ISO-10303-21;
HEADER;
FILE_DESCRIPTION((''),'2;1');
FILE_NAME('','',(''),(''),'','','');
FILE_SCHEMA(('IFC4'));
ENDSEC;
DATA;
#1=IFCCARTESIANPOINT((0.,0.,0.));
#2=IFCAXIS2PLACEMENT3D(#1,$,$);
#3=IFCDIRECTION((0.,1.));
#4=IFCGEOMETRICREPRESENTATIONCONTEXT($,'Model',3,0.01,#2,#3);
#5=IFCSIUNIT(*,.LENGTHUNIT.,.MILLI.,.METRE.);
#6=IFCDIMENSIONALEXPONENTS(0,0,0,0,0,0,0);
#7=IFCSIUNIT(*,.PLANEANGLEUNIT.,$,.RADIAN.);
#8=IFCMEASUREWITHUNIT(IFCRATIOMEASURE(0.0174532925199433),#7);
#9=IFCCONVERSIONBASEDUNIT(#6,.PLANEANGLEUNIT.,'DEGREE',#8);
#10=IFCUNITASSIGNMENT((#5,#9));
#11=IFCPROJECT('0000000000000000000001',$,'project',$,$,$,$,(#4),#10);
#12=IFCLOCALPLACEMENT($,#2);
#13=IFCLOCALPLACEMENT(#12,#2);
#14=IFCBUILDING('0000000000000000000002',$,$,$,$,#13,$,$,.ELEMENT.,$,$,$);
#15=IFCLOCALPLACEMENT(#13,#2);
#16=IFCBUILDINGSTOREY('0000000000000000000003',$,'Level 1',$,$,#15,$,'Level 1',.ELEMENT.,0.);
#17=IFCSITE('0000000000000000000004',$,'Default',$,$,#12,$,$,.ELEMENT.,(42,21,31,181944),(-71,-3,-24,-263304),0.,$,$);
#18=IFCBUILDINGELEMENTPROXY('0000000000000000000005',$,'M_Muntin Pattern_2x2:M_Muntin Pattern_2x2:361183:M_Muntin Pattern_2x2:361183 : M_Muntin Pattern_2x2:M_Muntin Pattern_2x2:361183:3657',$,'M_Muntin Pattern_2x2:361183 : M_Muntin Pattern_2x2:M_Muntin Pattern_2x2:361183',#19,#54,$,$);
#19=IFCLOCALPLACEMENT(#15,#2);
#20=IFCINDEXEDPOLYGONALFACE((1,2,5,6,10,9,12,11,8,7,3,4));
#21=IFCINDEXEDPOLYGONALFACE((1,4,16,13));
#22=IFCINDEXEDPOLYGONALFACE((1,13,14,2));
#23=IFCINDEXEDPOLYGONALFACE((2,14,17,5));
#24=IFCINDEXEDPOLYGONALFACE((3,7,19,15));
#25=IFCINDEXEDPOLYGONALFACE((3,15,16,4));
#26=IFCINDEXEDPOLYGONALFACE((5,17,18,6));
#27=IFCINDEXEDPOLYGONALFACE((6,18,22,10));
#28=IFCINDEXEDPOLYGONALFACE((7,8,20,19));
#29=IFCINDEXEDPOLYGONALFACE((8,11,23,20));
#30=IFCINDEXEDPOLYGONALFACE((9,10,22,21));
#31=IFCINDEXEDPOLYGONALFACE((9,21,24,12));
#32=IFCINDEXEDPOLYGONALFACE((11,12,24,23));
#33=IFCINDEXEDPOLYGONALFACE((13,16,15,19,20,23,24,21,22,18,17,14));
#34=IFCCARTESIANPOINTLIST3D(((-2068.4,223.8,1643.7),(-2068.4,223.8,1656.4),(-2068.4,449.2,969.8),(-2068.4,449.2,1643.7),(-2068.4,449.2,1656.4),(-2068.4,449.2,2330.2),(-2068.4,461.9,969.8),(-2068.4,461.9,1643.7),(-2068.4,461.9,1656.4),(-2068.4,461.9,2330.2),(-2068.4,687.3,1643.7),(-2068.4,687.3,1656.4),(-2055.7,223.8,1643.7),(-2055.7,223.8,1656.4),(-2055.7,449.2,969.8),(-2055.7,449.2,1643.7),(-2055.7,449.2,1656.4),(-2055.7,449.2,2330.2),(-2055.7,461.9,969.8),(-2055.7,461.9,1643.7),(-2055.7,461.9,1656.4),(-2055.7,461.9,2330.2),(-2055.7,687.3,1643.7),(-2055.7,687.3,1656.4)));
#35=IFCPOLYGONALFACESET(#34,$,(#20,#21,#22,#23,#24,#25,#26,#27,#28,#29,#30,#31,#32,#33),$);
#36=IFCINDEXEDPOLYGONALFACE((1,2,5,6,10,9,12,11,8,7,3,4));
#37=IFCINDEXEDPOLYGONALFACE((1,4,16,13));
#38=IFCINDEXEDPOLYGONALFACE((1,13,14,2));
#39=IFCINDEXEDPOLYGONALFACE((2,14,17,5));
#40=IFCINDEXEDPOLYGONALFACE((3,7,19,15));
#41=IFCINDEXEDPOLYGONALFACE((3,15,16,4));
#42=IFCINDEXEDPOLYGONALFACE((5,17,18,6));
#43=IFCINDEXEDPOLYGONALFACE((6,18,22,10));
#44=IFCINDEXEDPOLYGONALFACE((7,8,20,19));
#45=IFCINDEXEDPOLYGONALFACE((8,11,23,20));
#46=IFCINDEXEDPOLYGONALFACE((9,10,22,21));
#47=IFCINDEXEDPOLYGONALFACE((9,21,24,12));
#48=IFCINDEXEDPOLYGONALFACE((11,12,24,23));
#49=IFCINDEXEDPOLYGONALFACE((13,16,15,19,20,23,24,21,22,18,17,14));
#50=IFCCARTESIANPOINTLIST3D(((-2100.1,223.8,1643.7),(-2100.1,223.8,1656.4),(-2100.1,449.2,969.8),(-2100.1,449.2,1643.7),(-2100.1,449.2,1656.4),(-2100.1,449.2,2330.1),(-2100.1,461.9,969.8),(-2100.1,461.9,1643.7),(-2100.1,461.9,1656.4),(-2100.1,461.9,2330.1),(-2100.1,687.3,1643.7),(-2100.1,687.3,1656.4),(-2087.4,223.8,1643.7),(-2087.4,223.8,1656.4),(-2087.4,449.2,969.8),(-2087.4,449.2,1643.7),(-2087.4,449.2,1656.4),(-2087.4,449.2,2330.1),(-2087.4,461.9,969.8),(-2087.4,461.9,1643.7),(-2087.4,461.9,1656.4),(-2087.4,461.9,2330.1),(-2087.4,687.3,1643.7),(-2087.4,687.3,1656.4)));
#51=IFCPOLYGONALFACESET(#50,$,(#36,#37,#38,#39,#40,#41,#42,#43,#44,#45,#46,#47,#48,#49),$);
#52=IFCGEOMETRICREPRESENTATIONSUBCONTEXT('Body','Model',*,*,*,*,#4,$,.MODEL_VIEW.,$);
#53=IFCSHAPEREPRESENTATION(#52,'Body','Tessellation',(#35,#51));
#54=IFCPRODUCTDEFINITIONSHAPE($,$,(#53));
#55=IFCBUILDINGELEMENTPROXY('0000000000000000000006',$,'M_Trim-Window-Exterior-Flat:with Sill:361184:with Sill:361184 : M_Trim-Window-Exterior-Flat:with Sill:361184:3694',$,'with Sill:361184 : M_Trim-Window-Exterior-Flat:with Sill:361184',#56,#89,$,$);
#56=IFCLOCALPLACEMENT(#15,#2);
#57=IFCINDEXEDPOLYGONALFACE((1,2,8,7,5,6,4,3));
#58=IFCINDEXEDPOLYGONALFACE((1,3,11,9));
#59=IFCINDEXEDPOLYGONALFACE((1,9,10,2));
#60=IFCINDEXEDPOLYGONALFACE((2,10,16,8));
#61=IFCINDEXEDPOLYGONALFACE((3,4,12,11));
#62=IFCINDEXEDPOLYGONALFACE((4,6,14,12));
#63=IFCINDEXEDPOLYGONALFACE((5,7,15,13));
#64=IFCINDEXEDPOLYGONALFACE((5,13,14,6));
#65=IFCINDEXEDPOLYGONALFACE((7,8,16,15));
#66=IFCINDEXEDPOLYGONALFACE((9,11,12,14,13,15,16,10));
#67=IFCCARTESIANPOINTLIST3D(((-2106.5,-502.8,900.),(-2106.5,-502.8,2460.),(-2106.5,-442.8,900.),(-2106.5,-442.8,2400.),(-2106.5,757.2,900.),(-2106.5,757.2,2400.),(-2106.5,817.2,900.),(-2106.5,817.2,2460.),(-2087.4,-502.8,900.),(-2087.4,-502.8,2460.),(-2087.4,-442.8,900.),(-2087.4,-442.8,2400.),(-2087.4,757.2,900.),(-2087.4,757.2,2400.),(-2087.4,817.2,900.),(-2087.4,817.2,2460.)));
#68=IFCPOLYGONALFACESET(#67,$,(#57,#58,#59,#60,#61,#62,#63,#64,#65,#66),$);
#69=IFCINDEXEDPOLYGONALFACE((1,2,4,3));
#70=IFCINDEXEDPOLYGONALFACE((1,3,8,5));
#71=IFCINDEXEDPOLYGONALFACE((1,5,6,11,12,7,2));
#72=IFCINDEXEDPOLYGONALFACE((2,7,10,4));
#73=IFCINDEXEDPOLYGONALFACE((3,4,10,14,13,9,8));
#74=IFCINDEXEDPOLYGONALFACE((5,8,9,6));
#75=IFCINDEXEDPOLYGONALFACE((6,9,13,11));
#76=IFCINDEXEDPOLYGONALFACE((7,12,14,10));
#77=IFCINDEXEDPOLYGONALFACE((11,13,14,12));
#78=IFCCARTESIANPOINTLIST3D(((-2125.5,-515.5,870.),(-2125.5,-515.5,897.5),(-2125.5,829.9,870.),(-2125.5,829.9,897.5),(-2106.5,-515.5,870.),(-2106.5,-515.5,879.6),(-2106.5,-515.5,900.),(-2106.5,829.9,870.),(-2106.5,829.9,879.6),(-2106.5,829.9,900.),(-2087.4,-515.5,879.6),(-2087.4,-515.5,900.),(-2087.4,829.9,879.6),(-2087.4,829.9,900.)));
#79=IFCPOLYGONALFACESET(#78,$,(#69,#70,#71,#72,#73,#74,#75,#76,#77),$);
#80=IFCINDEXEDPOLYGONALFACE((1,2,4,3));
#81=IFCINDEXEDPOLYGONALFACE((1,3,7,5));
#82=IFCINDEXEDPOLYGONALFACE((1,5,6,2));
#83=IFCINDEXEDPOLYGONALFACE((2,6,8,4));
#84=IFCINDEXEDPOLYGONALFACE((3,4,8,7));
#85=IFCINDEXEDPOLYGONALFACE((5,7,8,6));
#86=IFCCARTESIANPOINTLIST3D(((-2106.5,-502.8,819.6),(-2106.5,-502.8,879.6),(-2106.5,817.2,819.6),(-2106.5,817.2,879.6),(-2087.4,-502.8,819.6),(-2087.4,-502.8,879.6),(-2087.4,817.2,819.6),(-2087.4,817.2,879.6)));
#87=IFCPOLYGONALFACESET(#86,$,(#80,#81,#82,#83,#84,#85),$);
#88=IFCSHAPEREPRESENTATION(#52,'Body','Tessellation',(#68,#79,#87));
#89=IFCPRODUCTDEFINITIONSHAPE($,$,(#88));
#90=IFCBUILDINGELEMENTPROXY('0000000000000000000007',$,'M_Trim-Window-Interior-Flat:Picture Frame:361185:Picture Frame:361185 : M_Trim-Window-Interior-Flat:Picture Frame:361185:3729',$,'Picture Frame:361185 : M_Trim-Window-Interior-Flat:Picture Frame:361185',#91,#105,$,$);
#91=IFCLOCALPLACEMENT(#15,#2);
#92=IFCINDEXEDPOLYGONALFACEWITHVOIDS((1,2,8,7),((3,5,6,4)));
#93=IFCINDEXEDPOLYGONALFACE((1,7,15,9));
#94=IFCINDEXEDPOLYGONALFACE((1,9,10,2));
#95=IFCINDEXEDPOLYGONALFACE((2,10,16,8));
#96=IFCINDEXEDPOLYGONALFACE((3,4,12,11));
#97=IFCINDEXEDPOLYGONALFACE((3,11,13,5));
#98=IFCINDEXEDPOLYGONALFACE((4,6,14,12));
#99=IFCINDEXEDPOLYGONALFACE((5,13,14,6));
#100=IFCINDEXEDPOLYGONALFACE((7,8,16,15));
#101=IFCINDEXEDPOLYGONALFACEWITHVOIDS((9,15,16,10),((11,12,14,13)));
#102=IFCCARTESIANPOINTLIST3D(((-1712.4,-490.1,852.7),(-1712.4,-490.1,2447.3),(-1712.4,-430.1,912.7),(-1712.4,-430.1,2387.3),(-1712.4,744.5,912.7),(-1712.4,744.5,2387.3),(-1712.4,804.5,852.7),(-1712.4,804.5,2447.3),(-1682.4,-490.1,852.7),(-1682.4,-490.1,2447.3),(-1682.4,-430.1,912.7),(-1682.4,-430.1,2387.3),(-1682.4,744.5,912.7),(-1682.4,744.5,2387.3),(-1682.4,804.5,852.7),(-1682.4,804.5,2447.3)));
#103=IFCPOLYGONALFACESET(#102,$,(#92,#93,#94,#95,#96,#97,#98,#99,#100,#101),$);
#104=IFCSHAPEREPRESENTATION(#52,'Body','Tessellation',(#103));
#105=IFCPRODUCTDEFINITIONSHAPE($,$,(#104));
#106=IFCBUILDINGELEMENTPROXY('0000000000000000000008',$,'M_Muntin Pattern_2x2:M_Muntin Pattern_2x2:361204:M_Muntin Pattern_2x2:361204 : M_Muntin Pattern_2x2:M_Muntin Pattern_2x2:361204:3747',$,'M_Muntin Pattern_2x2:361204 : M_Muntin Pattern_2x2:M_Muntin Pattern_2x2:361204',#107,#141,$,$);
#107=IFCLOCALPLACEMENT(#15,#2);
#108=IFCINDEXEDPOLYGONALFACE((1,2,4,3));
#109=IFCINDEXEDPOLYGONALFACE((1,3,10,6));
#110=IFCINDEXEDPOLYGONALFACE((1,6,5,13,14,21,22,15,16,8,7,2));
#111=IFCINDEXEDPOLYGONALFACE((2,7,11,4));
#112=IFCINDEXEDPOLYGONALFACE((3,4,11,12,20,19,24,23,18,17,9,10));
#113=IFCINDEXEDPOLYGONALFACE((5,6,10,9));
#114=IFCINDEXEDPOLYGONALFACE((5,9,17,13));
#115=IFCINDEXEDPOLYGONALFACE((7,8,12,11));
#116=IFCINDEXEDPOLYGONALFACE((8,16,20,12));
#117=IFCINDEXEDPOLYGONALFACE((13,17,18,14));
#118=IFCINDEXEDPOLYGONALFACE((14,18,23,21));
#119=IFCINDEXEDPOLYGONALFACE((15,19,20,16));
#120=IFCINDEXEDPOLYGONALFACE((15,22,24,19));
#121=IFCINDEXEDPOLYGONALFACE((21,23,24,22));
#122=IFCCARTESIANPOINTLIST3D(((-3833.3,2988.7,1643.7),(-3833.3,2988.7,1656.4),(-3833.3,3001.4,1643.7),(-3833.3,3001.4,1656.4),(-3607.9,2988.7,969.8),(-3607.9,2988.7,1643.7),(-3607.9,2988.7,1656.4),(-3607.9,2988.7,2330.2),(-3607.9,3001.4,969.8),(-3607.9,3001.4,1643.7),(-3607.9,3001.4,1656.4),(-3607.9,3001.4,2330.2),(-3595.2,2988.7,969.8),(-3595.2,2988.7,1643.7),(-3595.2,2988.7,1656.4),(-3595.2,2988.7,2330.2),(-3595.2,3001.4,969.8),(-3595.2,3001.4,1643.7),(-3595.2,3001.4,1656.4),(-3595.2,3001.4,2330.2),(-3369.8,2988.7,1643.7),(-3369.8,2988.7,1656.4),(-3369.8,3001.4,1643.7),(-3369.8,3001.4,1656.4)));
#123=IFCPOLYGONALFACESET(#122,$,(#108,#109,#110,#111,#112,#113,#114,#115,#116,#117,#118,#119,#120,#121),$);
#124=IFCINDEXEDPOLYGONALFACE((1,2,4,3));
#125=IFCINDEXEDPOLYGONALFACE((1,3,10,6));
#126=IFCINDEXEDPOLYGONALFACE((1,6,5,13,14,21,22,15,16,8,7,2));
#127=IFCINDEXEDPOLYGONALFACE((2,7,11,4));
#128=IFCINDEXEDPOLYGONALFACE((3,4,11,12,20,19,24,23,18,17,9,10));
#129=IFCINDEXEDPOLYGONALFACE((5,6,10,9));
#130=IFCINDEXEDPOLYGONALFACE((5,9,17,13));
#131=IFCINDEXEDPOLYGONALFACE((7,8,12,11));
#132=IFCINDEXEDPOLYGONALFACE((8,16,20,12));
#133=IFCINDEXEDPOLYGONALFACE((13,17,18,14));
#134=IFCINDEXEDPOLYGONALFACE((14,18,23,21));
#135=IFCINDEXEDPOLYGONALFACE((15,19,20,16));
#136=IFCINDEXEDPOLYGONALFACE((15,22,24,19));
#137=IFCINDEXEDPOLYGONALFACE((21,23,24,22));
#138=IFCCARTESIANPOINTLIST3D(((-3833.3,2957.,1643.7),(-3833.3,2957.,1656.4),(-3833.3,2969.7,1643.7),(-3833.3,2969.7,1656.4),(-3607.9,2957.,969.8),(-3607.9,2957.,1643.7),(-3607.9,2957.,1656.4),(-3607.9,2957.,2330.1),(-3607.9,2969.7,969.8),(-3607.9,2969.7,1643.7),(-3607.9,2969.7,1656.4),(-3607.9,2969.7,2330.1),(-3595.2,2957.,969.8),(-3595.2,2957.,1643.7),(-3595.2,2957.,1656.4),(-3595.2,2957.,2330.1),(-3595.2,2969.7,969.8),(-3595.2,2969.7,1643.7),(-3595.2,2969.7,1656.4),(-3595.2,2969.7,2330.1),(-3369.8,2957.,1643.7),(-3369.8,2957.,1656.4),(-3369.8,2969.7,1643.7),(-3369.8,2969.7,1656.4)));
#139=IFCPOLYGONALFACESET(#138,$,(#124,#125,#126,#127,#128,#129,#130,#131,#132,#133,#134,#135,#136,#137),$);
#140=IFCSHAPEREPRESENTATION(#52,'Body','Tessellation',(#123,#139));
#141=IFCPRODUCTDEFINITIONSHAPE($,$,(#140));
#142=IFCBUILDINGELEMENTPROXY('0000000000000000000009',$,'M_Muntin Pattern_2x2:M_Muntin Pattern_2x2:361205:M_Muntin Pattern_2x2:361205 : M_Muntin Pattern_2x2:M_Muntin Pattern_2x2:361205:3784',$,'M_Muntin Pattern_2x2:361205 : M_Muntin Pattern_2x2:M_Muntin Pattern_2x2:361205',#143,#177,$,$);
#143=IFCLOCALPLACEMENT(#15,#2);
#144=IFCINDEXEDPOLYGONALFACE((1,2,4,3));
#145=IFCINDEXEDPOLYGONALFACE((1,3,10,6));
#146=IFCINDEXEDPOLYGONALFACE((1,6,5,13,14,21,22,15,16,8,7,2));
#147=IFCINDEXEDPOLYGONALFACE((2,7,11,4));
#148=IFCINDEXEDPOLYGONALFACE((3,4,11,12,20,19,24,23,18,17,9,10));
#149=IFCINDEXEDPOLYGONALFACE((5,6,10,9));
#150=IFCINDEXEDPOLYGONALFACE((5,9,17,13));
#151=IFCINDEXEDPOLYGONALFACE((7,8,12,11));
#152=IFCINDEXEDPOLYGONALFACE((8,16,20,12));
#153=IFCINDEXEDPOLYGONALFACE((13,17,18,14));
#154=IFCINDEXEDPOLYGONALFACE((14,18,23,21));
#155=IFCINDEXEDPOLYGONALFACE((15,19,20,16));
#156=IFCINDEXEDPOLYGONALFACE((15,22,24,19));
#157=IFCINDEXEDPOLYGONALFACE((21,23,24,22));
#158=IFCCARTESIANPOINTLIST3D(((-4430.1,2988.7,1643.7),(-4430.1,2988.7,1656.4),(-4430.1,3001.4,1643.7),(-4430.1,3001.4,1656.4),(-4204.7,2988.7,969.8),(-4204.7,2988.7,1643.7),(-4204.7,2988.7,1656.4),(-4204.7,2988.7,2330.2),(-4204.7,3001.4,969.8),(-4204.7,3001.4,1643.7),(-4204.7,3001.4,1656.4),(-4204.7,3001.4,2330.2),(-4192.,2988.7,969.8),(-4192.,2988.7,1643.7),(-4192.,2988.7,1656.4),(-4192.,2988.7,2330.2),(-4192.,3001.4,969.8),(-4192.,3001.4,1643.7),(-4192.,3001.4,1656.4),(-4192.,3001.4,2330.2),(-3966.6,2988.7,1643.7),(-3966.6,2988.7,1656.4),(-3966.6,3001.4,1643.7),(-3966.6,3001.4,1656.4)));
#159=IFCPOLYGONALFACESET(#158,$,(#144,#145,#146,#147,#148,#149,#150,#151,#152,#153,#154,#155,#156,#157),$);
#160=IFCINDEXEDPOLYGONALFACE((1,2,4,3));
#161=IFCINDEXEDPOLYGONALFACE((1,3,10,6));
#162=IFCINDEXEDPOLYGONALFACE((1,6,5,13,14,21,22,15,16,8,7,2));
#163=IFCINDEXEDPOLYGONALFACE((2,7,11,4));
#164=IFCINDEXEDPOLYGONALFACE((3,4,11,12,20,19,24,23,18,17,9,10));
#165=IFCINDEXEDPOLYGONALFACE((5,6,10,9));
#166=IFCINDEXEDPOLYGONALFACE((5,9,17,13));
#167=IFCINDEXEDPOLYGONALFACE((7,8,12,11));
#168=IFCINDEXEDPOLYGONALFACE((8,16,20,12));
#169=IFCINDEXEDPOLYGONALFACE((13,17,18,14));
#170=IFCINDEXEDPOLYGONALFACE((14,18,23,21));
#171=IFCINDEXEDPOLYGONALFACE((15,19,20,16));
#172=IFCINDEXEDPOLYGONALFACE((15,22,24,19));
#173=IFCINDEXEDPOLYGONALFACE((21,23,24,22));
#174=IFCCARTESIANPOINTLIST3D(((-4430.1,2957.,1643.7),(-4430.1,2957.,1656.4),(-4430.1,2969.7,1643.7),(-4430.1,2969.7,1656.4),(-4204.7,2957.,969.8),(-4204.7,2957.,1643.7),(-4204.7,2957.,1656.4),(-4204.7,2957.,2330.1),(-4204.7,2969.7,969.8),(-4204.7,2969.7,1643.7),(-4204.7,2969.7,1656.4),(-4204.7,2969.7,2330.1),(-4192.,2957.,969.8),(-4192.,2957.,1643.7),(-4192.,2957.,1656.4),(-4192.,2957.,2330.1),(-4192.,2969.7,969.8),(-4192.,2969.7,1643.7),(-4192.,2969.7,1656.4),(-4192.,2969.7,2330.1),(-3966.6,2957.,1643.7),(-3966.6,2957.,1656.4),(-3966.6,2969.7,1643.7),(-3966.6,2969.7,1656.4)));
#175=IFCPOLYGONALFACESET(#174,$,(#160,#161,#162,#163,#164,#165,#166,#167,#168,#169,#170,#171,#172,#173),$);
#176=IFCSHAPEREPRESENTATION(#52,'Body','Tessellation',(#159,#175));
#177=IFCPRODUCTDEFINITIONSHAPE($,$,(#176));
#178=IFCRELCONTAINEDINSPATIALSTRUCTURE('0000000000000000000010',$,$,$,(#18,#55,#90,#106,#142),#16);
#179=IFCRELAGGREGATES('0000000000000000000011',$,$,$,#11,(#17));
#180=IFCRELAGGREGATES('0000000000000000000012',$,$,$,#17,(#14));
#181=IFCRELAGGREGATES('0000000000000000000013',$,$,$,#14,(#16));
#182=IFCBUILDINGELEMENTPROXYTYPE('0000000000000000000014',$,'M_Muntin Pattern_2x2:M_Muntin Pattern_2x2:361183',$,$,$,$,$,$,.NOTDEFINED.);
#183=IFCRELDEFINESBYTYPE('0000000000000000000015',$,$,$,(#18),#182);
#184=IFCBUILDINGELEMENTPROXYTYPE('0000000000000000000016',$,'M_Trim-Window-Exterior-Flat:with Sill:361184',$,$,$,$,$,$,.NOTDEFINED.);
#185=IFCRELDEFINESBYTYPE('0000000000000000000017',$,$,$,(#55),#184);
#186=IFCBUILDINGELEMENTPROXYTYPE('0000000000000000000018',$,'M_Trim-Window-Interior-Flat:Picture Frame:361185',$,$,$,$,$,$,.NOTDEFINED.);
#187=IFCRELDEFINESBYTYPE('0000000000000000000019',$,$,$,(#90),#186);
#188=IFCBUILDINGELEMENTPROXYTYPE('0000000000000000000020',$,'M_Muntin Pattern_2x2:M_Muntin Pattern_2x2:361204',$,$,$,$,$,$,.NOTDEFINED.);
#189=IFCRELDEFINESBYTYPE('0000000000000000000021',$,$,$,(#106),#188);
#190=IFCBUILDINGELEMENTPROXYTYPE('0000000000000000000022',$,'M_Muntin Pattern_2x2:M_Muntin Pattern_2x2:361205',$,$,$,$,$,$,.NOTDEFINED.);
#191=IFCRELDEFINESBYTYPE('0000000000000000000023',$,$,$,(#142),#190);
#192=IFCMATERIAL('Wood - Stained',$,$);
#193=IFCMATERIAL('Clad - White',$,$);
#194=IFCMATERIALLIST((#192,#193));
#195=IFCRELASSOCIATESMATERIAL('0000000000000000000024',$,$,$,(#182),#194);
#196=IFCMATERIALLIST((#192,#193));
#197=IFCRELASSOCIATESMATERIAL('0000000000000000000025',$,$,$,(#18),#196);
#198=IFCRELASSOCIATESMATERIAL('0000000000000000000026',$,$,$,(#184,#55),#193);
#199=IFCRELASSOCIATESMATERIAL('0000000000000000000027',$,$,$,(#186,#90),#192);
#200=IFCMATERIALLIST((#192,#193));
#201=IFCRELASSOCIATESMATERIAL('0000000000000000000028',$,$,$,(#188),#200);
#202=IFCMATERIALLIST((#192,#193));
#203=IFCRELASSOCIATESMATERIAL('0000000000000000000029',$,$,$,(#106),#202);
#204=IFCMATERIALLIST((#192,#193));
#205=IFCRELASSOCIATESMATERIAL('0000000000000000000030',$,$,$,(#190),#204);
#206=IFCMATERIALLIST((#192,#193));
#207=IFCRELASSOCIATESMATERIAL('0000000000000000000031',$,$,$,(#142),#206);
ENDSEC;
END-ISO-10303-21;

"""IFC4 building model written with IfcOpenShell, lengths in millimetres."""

from ifc_helpers import new_model, entity, si_unit, converted_unit, direction, frame, origin, origin_2d_with_axis, place, context, subcontext, project, spatial, polyline, rectangle, outline, extrude, source, transform, mapped, material, material_list, type_object, type_shapes, element, save


model = new_model("IFC4")

# Units and contexts
model_context = context("Model", 3, precision=0.01, world=origin(), true_north=direction((0.0, 1.0)))
body_context = subcontext(model_context, "Body", "Model", "MODEL_VIEW")
ifc_project = project(units=[si_unit("LENGTHUNIT", "METRE", prefix="MILLI"), converted_unit("PLANEANGLEUNIT", "DEGREE", entity("IfcRatioMeasure", 0.0174532925199433), si_unit("PLANEANGLEUNIT", "RADIAN"), dimensions=[0, 0, 0, 0, 0, 0, 0])], contexts=[model_context])

# Site, building, storey
site_placement = place(None, origin())
site = spatial("IfcSite", under=ifc_project, at=site_placement, Name="Default", CompositionType="ELEMENT", RefLatitude=(42, 21, 31, 181944), RefLongitude=(-71, -3, -24, -263304), RefElevation=0.0)
building_placement = place(site_placement, origin())
building = spatial("IfcBuilding", under=site, at=building_placement, CompositionType="ELEMENT")
storey_placement = place(building_placement, origin())
storey = spatial("IfcBuildingStorey", under=building, at=storey_placement, Name="Level 1", LongName="Level 1", CompositionType="ELEMENT", Elevation=0.0)

# Building element proxies
ifc_material_1 = material(Name="Wood - Stained")
ifc_material_2 = material(Name="Clad - White")
ifc_material_list_1 = material_list([ifc_material_1, ifc_material_2])
ifc_material_list_2 = material_list([ifc_material_1, ifc_material_2])
building_element_proxy_type_1 = type_object("IfcBuildingElementProxyType", Name="M_Muntin Pattern_2x2:M_Muntin Pattern_2x2:361183", PredefinedType="NOTDEFINED", material=ifc_material_list_2)
shared_shape_1 = source(origin(), body_context, "Body", "SweptSolid", [
    extrude(outline(polyline([(-6.4, -680.1), (6.3, -680.1), (6.3, -6.4), (231.7, -6.4), (231.7, 6.3), (6.3, 6.3), (6.3, 680.2), (-6.4, 680.2), (-6.4, 6.3), (-231.7, 6.3), (-231.7, -6.4), (-6.4, -6.4), (-6.4, -680.1)])), frame((-2068.4, 455.6, 1650.0), z_axis=(1.0, 0.0, 0.0), x_axis=(0.0, -1.0, 0.0)), (0.0, 0.0, 1.0), 12.7),
    extrude(outline(polyline([(-6.4, -680.1), (6.3, -680.1), (6.3, -6.4), (231.7, -6.4), (231.7, 6.3), (6.3, 6.3), (6.3, 680.2), (-6.4, 680.2), (-6.4, 6.3), (-231.7, 6.3), (-231.7, -6.4), (-6.4, -6.4), (-6.4, -680.1)])), frame((-2100.1, 455.6, 1650.0), z_axis=(1.0, 0.0, 0.0), x_axis=(0.0, -1.0, 0.0)), (0.0, 0.0, 1.0), 12.7),
])
type_shapes(building_element_proxy_type_1, [shared_shape_1])
proxy_1_placement = place(storey_placement, origin())
element("IfcBuildingElementProxy", 1, at=proxy_1_placement, inside=storey, type_object=building_element_proxy_type_1, material=ifc_material_list_1, Name="M_Muntin Pattern_2x2:M_Muntin Pattern_2x2:361183:M_Muntin Pattern_2x2:361183 : M_Muntin Pattern_2x2:M_Muntin Pattern_2x2:361183:3657", ObjectType="M_Muntin Pattern_2x2:361183 : M_Muntin Pattern_2x2:M_Muntin Pattern_2x2:361183", context=body_context, shape_type="MappedRepresentation", body=[
    mapped(shared_shape_1, transform((0.0, 0.0, 0.0), scale=1.0)),
])
building_element_proxy_type_2 = type_object("IfcBuildingElementProxyType", Name="M_Trim-Window-Exterior-Flat:with Sill:361184", PredefinedType="NOTDEFINED", material=ifc_material_2)
shared_shape_2 = source(origin(), body_context, "Body", "SweptSolid", [
    extrude(outline(polyline([(-765.0, -660.0), (795.0, -660.0), (795.0, 660.0), (-765.0, 660.0), (-765.0, 600.0), (735.0, 600.0), (735.0, -600.0), (-765.0, -600.0), (-765.0, -660.0)])), frame((-2106.5, 157.2, 1665.0), z_axis=(1.0, 0.0, 0.0), x_axis=(0.0, 0.0, 1.0)), (0.0, 0.0, 1.0), 19.1),
    extrude(outline(polyline([(0.0, -15.2), (19.0, -15.2), (19.0, 12.3), (0.0, 14.8), (-19.0, 14.8), (-19.0, -5.7), (0.0, -5.7), (0.0, -15.2)])), frame((-2106.5, -515.5, 885.2), z_axis=(0.0, 1.0, 0.0), x_axis=(-1.0, 0.0, 0.0)), (0.0, 0.0, 1.0), 1345.4),
    extrude(rectangle(XDim=19.1, YDim=1320.0, at=origin_2d_with_axis()), frame((-2097.0, 157.2, 819.6)), (0.0, 0.0, 1.0), 60.0),
])
type_shapes(building_element_proxy_type_2, [shared_shape_2])
proxy_2_placement = place(storey_placement, origin())
element("IfcBuildingElementProxy", 2, at=proxy_2_placement, inside=storey, type_object=building_element_proxy_type_2, material=ifc_material_2, Name="M_Trim-Window-Exterior-Flat:with Sill:361184:with Sill:361184 : M_Trim-Window-Exterior-Flat:with Sill:361184:3694", ObjectType="with Sill:361184 : M_Trim-Window-Exterior-Flat:with Sill:361184", context=body_context, shape_type="MappedRepresentation", body=[
    mapped(shared_shape_2, transform((0.0, 0.0, 0.0), scale=1.0)),
])
building_element_proxy_type_3 = type_object("IfcBuildingElementProxyType", Name="M_Trim-Window-Interior-Flat:Picture Frame:361185", PredefinedType="NOTDEFINED", material=ifc_material_1)
shared_shape_3 = source(origin(), body_context, "Body", "SweptSolid", [
    extrude(outline(polyline([(-797.3, -647.3), (797.3, -647.3), (797.3, 647.3), (-797.3, 647.3), (-797.3, -647.3)]), holes=[polyline([(737.3, 587.3), (737.3, -587.3), (-737.3, -587.3), (-737.3, 587.3), (737.3, 587.3)])]), frame((-1712.4, 157.2, 1650.0), z_axis=(1.0, 0.0, 0.0), x_axis=(0.0, 0.0, -1.0)), (0.0, 0.0, 1.0), 30.0),
])
type_shapes(building_element_proxy_type_3, [shared_shape_3])
proxy_3_placement = place(storey_placement, origin())
element("IfcBuildingElementProxy", 3, at=proxy_3_placement, inside=storey, type_object=building_element_proxy_type_3, material=ifc_material_1, Name="M_Trim-Window-Interior-Flat:Picture Frame:361185:Picture Frame:361185 : M_Trim-Window-Interior-Flat:Picture Frame:361185:3729", ObjectType="Picture Frame:361185 : M_Trim-Window-Interior-Flat:Picture Frame:361185", context=body_context, shape_type="MappedRepresentation", body=[
    mapped(shared_shape_3, transform((0.0, 0.0, 0.0), scale=1.0)),
])
ifc_material_list_3 = material_list([ifc_material_1, ifc_material_2])
ifc_material_list_4 = material_list([ifc_material_1, ifc_material_2])
building_element_proxy_type_4 = type_object("IfcBuildingElementProxyType", Name="M_Muntin Pattern_2x2:M_Muntin Pattern_2x2:361204", PredefinedType="NOTDEFINED", material=ifc_material_list_4)
shared_shape_4 = source(origin(), body_context, "Body", "SweptSolid", [
    extrude(outline(polyline([(-680.2, 6.4), (-680.2, -6.3), (-6.4, -6.3), (-6.4, -231.7), (6.3, -231.7), (6.3, -6.3), (680.2, -6.3), (680.2, 6.4), (6.3, 6.4), (6.3, 231.7), (-6.4, 231.7), (-6.4, 6.4), (-680.2, 6.4)])), frame((-3601.5, 2988.7, 1650.0), z_axis=(0.0, -1.0, 0.0), x_axis=(0.0, 0.0, -1.0)), (0.0, 0.0, -1.0), 12.7),
    extrude(outline(polyline([(-680.1, 6.4), (-680.1, -6.3), (-6.4, -6.3), (-6.4, -231.7), (6.3, -231.7), (6.3, -6.3), (680.2, -6.3), (680.2, 6.4), (6.3, 6.4), (6.3, 231.7), (-6.4, 231.7), (-6.4, 6.4), (-680.1, 6.4)])), frame((-3601.5, 2957.0, 1650.0), z_axis=(0.0, -1.0, 0.0), x_axis=(0.0, 0.0, -1.0)), (0.0, 0.0, -1.0), 12.7),
])
type_shapes(building_element_proxy_type_4, [shared_shape_4])
proxy_4_placement = place(storey_placement, origin())
element("IfcBuildingElementProxy", 4, at=proxy_4_placement, inside=storey, type_object=building_element_proxy_type_4, material=ifc_material_list_3, Name="M_Muntin Pattern_2x2:M_Muntin Pattern_2x2:361204:M_Muntin Pattern_2x2:361204 : M_Muntin Pattern_2x2:M_Muntin Pattern_2x2:361204:3747", ObjectType="M_Muntin Pattern_2x2:361204 : M_Muntin Pattern_2x2:M_Muntin Pattern_2x2:361204", context=body_context, shape_type="MappedRepresentation", body=[
    mapped(shared_shape_4, transform((0.0, 0.0, 0.0), scale=1.0)),
])
ifc_material_list_5 = material_list([ifc_material_1, ifc_material_2])
ifc_material_list_6 = material_list([ifc_material_1, ifc_material_2])
building_element_proxy_type_5 = type_object("IfcBuildingElementProxyType", Name="M_Muntin Pattern_2x2:M_Muntin Pattern_2x2:361205", PredefinedType="NOTDEFINED", material=ifc_material_list_6)
shared_shape_5 = source(origin(), body_context, "Body", "SweptSolid", [
    extrude(outline(polyline([(-6.4, -680.1), (6.3, -680.1), (6.3, -6.4), (231.7, -6.4), (231.7, 6.3), (6.3, 6.3), (6.3, 680.2), (-6.4, 680.2), (-6.4, 6.3), (-231.7, 6.3), (-231.7, -6.4), (-6.4, -6.4), (-6.4, -680.1)])), frame((-4198.4, 2988.7, 1650.0), z_axis=(0.0, 1.0, 0.0), x_axis=(1.0, 0.0, 0.0)), (0.0, 0.0, 1.0), 12.7),
    extrude(outline(polyline([(-6.4, -680.1), (6.3, -680.1), (6.3, -6.4), (231.7, -6.4), (231.7, 6.3), (6.3, 6.3), (6.3, 680.2), (-6.4, 680.2), (-6.4, 6.3), (-231.7, 6.3), (-231.7, -6.4), (-6.4, -6.4), (-6.4, -680.1)])), frame((-4198.4, 2957.0, 1650.0), z_axis=(0.0, 1.0, 0.0), x_axis=(1.0, 0.0, 0.0)), (0.0, 0.0, 1.0), 12.7),
])
type_shapes(building_element_proxy_type_5, [shared_shape_5])
proxy_5_placement = place(storey_placement, origin())
element("IfcBuildingElementProxy", 5, at=proxy_5_placement, inside=storey, type_object=building_element_proxy_type_5, material=ifc_material_list_5, Name="M_Muntin Pattern_2x2:M_Muntin Pattern_2x2:361205:M_Muntin Pattern_2x2:361205 : M_Muntin Pattern_2x2:M_Muntin Pattern_2x2:361205:3784", ObjectType="M_Muntin Pattern_2x2:361205 : M_Muntin Pattern_2x2:M_Muntin Pattern_2x2:361205", context=body_context, shape_type="MappedRepresentation", body=[
    mapped(shared_shape_5, transform((0.0, 0.0, 0.0), scale=1.0)),
])

save(model, "model.ifc")
